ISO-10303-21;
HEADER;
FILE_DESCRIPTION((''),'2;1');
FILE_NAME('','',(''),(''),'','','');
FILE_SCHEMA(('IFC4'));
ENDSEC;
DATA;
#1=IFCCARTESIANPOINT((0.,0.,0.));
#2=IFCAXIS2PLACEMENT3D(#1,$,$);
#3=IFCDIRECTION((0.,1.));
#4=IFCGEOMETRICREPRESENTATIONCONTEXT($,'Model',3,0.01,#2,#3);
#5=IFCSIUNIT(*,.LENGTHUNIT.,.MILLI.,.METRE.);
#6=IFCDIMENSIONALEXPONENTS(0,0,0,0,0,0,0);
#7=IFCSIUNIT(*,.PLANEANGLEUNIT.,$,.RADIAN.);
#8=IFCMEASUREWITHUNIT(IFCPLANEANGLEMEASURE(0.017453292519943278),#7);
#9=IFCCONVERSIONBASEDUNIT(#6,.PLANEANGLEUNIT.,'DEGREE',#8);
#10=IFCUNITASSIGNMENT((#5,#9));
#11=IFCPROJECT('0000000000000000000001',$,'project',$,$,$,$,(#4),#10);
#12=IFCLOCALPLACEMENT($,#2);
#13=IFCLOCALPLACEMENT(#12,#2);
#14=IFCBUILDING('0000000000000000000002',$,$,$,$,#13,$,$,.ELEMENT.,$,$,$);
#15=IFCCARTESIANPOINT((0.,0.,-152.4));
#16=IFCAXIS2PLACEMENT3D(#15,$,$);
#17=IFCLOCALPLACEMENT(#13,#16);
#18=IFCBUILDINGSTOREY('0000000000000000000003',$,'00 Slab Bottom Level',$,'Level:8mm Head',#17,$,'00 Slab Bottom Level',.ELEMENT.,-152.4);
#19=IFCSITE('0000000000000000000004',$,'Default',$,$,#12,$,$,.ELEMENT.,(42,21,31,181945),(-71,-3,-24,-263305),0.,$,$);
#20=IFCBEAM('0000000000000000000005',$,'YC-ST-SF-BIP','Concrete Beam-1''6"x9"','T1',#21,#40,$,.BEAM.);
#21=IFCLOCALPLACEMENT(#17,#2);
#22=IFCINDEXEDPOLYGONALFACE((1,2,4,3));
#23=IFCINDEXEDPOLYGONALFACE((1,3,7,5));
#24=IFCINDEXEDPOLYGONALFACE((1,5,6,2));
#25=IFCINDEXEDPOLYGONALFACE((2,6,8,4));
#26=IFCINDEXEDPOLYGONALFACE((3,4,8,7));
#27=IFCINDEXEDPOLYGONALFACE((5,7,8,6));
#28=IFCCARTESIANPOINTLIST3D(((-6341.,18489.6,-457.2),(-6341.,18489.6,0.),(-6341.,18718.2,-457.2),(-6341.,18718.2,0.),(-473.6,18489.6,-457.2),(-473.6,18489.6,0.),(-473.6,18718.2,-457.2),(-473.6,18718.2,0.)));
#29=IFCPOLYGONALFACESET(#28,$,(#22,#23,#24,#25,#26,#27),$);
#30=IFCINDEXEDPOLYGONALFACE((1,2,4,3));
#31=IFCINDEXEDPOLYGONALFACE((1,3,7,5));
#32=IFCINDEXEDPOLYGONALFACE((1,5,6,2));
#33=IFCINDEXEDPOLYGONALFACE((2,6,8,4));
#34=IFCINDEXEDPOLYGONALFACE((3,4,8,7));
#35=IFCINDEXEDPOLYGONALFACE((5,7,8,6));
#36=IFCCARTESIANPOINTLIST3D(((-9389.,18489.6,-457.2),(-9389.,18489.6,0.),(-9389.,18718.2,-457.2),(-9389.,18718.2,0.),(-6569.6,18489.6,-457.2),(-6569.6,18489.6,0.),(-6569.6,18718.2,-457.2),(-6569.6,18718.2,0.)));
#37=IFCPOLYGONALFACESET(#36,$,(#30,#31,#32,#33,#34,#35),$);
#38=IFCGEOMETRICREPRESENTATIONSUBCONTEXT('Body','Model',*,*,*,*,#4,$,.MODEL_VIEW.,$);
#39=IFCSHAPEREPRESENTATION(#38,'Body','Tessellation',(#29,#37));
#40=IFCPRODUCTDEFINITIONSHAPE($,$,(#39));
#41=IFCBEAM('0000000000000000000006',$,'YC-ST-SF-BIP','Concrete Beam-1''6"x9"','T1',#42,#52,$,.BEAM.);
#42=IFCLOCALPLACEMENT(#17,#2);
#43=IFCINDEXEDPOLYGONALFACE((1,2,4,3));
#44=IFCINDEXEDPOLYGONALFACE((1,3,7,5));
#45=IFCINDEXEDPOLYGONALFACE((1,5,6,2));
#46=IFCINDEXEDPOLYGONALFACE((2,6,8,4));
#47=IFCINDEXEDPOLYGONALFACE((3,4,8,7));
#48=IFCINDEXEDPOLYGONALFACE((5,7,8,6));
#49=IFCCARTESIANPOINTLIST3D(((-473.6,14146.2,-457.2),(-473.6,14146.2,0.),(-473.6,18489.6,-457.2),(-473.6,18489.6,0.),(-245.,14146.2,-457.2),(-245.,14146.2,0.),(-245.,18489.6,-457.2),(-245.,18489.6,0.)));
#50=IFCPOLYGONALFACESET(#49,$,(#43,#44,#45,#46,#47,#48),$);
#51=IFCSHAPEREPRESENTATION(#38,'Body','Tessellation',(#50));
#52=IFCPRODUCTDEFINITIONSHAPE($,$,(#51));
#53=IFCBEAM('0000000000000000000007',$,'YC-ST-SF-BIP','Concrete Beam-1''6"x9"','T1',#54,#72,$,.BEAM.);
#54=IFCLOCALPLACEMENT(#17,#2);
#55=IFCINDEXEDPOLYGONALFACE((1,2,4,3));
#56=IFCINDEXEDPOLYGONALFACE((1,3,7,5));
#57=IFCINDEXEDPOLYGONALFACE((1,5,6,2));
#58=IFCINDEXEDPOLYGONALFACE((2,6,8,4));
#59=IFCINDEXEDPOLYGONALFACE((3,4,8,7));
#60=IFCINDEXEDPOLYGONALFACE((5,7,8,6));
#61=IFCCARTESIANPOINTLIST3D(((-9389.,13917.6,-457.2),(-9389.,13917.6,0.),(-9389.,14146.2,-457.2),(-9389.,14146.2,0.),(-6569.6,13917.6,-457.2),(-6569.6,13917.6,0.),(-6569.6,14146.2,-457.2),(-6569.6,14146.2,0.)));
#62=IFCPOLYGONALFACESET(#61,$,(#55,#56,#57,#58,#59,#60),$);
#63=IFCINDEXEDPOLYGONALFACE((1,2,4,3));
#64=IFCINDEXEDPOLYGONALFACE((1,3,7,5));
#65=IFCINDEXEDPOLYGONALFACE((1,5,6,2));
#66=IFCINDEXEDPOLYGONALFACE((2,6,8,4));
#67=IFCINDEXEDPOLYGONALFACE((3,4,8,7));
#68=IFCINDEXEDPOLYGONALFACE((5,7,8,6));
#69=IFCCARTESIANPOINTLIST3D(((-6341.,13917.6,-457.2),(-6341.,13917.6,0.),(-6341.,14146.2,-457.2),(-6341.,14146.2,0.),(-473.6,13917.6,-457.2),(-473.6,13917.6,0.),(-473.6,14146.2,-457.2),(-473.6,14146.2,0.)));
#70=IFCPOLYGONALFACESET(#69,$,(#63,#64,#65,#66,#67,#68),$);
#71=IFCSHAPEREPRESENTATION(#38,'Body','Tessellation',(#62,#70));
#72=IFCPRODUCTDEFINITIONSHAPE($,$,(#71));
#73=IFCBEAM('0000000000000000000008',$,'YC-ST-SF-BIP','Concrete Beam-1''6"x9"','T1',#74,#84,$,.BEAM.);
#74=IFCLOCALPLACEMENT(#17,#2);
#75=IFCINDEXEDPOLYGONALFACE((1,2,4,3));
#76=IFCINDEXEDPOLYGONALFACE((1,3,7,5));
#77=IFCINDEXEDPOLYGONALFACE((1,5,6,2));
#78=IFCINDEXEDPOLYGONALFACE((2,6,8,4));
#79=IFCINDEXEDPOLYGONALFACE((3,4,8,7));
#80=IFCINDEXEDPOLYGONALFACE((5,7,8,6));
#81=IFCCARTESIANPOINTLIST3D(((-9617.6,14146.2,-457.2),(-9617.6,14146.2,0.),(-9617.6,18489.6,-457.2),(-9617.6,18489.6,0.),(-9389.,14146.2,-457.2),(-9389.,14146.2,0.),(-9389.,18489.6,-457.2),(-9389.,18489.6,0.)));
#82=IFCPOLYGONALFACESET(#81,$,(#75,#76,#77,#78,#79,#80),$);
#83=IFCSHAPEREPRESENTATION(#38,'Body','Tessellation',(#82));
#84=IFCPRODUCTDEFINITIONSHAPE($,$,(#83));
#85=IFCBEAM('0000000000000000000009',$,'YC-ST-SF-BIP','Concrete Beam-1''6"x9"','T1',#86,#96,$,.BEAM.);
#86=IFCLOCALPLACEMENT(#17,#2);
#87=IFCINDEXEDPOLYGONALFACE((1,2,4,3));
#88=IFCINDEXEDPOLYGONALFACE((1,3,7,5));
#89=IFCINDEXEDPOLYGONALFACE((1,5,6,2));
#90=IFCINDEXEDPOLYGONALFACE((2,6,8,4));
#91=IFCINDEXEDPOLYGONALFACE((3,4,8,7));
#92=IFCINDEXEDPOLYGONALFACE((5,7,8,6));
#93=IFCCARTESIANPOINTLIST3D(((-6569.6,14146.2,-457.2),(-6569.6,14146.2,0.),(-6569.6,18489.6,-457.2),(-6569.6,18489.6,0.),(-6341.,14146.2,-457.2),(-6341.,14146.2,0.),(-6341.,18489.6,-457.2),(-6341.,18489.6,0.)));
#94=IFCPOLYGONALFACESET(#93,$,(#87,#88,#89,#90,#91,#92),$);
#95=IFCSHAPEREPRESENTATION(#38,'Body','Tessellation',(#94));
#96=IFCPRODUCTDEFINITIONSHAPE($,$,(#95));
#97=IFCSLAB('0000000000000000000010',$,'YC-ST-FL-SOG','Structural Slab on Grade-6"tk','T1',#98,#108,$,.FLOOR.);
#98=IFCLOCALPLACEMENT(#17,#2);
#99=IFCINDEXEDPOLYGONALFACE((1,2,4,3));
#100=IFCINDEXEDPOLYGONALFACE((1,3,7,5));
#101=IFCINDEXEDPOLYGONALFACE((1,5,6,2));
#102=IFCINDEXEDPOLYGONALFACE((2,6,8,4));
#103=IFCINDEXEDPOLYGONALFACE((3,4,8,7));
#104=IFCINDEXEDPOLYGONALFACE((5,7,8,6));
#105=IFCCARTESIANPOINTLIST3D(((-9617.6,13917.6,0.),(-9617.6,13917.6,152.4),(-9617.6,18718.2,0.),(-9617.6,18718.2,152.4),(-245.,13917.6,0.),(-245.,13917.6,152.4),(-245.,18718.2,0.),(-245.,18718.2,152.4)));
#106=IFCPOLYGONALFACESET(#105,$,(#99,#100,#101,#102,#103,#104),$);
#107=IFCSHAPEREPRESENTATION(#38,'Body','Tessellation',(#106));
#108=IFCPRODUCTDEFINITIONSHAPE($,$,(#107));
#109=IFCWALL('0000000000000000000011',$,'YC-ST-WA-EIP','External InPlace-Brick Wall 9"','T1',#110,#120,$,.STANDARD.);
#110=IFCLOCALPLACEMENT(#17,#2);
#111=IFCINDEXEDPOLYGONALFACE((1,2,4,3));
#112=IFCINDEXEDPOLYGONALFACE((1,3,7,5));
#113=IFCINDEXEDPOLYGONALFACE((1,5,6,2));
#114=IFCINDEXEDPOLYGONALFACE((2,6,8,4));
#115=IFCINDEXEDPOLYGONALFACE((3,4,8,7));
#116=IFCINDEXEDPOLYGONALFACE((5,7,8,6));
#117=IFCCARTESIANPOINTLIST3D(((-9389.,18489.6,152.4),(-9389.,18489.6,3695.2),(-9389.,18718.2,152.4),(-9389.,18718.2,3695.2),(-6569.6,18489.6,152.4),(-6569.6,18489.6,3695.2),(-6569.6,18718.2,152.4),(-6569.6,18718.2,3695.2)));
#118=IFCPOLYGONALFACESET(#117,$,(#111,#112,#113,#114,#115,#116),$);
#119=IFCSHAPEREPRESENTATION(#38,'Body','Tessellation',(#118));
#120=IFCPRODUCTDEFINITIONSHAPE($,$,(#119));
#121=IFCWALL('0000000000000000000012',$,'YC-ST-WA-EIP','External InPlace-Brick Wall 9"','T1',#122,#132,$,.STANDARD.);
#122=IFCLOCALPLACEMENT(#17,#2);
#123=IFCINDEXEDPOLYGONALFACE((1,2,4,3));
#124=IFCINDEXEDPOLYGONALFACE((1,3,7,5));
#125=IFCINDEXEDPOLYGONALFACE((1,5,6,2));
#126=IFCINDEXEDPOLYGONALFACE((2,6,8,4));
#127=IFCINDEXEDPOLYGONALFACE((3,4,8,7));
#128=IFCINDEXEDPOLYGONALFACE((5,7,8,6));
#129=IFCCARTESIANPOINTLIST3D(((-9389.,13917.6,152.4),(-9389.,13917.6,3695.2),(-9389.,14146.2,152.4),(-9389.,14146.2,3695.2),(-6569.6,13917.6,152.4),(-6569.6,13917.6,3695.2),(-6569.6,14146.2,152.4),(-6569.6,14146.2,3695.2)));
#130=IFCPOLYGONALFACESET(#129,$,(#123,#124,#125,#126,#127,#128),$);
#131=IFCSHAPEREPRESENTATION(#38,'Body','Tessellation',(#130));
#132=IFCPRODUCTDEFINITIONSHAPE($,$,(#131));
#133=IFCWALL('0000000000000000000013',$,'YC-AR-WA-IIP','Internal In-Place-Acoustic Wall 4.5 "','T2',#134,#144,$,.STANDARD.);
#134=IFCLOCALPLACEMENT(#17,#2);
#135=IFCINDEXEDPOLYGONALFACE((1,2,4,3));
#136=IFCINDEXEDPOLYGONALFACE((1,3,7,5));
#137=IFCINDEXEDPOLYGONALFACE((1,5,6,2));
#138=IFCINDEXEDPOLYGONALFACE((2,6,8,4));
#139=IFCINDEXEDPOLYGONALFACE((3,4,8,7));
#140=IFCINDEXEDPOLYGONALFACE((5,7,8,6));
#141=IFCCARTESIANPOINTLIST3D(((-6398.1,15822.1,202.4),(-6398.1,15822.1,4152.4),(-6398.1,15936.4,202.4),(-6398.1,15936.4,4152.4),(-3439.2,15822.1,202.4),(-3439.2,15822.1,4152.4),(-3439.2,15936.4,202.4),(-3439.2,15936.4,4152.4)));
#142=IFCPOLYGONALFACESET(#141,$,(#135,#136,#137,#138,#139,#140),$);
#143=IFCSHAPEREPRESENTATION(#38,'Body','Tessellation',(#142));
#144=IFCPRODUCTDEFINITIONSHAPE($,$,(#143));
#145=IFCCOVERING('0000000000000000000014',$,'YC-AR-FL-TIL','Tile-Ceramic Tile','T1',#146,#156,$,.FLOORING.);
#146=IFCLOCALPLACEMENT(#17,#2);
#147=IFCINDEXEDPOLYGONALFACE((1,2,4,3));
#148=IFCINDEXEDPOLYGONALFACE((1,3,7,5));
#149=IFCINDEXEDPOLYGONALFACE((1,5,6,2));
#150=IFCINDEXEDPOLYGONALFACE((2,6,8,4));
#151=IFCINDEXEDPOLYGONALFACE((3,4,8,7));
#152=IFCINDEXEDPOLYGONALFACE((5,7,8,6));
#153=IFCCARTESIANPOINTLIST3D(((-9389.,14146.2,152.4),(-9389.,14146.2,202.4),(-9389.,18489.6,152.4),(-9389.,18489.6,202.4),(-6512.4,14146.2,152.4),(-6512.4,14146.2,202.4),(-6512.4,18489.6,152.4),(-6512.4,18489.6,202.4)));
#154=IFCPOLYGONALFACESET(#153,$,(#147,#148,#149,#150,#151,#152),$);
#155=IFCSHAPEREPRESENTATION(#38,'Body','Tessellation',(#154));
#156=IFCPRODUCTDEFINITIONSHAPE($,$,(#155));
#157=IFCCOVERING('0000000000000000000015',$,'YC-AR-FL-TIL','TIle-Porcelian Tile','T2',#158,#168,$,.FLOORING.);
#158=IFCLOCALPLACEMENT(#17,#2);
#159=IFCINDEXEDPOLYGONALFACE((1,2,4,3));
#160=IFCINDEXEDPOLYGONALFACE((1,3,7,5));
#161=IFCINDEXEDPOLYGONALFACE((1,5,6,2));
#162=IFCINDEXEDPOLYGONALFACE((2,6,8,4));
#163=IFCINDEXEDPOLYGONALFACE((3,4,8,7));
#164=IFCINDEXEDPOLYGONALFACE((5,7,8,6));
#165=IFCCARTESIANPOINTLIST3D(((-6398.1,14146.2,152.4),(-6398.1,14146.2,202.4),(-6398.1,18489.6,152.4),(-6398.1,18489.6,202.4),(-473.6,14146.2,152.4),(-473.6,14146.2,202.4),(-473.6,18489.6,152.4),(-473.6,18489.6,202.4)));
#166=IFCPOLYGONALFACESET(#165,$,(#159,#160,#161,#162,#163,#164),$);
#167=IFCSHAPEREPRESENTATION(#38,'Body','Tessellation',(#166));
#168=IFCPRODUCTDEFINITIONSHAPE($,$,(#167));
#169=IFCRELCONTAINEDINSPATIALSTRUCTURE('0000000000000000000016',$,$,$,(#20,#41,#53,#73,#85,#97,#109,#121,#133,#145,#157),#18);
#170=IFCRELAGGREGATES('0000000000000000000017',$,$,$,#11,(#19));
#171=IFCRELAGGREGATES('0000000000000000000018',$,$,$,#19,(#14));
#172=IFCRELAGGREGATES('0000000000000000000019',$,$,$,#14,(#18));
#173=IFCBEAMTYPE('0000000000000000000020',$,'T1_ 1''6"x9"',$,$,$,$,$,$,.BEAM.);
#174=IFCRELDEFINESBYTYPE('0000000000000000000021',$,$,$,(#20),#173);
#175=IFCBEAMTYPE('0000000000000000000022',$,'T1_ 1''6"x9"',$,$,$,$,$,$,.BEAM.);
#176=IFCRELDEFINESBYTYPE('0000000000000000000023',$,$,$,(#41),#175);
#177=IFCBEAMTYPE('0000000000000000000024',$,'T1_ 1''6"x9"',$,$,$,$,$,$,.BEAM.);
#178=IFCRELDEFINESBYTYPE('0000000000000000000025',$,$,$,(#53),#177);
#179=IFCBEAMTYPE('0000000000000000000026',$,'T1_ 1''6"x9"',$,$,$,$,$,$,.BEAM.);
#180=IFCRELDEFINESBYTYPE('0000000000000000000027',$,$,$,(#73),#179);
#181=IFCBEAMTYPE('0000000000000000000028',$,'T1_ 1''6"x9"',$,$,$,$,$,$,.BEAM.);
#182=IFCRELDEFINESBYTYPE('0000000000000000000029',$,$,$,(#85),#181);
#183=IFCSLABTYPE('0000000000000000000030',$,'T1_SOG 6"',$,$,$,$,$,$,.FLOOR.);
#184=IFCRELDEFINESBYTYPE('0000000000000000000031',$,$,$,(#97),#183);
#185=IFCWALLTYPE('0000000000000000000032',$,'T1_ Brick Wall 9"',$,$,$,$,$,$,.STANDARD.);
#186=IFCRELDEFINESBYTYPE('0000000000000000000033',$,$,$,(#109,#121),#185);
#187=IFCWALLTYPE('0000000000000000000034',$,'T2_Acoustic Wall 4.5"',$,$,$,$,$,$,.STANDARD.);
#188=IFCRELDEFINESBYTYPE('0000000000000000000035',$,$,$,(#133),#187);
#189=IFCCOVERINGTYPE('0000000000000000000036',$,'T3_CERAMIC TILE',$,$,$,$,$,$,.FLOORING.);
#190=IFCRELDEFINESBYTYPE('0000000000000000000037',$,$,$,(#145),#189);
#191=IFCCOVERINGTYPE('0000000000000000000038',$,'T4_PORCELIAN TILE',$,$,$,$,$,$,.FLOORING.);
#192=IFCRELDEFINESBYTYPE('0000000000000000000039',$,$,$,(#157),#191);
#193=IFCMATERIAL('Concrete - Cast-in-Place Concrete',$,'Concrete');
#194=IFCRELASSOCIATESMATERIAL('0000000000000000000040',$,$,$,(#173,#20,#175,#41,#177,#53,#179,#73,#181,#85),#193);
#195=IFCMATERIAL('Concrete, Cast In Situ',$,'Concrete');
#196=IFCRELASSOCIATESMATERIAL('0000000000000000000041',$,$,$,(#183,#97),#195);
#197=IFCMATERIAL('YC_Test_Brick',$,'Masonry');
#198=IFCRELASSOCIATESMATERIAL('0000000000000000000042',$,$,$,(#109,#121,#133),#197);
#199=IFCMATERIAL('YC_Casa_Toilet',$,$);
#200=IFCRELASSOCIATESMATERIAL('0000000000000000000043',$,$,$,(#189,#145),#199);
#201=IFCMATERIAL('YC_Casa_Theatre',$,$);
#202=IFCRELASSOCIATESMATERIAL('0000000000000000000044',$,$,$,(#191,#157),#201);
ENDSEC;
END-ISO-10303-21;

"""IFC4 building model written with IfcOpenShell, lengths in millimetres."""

from ifc_helpers import new_model, entity, si_unit, converted_unit, direction, frame, origin, place, context, subcontext, project, spatial, indexed_curve, outline, extrude, source, transform, mapped, material, type_object, type_shapes, element, save


model = new_model("IFC4")

# Units and contexts
model_context = context("Model", 3, precision=0.01, world=origin(), true_north=direction((0.0, 1.0)))
body_context = subcontext(model_context, "Body", "Model", "MODEL_VIEW")
ifc_project = project(units=[si_unit("LENGTHUNIT", "METRE", prefix="MILLI"), converted_unit("PLANEANGLEUNIT", "DEGREE", entity("IfcPlaneAngleMeasure", 0.017453292519943278), si_unit("PLANEANGLEUNIT", "RADIAN"), dimensions=[0, 0, 0, 0, 0, 0, 0])], contexts=[model_context])

# Site, building, storey
site_placement = place(None, origin())
site = spatial("IfcSite", under=ifc_project, at=site_placement, Name="Default", CompositionType="ELEMENT", RefLatitude=(42, 21, 31, 181945), RefLongitude=(-71, -3, -24, -263305), RefElevation=0.0)
building_placement = place(site_placement, origin())
building = spatial("IfcBuilding", under=site, at=building_placement, CompositionType="ELEMENT")
storey_placement = place(building_placement, frame((0.0, 0.0, -152.4)))
storey = spatial("IfcBuildingStorey", under=building, at=storey_placement, Name="00 Slab Bottom Level", ObjectType="Level:8mm Head", LongName="00 Slab Bottom Level", CompositionType="ELEMENT", Elevation=-152.4)

# Beams
ifc_material_1 = material(Name="Concrete - Cast-in-Place Concrete", Category="Concrete")
beam_type_1 = type_object("IfcBeamType", Name="T1_ 1'6\"x9\"", PredefinedType="BEAM", material=ifc_material_1)
shared_shape_1 = source(origin(), body_context, "Body", "SweptSolid", [
    extrude(outline(indexed_curve([(-228.6, -114.3), (228.6, -114.3), (228.6, 114.3), (-228.6, 114.3), (-228.6, -114.3)], self_intersect=False)), frame((-6341.0, 18603.9, -381.0), z_axis=(1.0, 0.0, 0.0), x_axis=(0.0, 0.0, -1.0)), (0.0, 0.0, 1.0), 5867.4),
    extrude(outline(indexed_curve([(-228.6, -114.3), (228.6, -114.3), (228.6, 114.3), (-228.6, 114.3), (-228.6, -114.3)], self_intersect=False)), frame((-9389.0, 18603.9, -381.0), z_axis=(1.0, 0.0, 0.0), x_axis=(0.0, 0.0, -1.0)), (0.0, 0.0, 1.0), 2819.4),
])
type_shapes(beam_type_1, [shared_shape_1])
beam_1_placement = place(storey_placement, frame((0.0, 0.0, 152.4)))
element("IfcBeam", 1, at=beam_1_placement, inside=storey, type_object=beam_type_1, material=ifc_material_1, Name="YC-ST-SF-BIP", Description="Concrete Beam-1'6\"x9\"", ObjectType="T1", PredefinedType="BEAM", context=body_context, shape_type="MappedRepresentation", body=[
    mapped(shared_shape_1, transform((0.0, 0.0, 0.0), scale=1.0)),
])
beam_type_2 = type_object("IfcBeamType", Name="T1_ 1'6\"x9\"", PredefinedType="BEAM", material=ifc_material_1)
shared_shape_2 = source(origin(), body_context, "Body", "SweptSolid", [
    extrude(outline(indexed_curve([(-114.3, -228.6), (114.3, -228.6), (114.3, 228.6), (-114.3, 228.6), (-114.3, -228.6)], self_intersect=False)), frame((-359.3, 18489.6, -381.0), z_axis=(0.0, -1.0, 0.0), x_axis=(-1.0, 0.0, 0.0)), (0.0, 0.0, 1.0), 4343.4),
])
type_shapes(beam_type_2, [shared_shape_2])
beam_2_placement = place(storey_placement, frame((0.0, 0.0, 152.4)))
element("IfcBeam", 2, at=beam_2_placement, inside=storey, type_object=beam_type_2, material=ifc_material_1, Name="YC-ST-SF-BIP", Description="Concrete Beam-1'6\"x9\"", ObjectType="T1", PredefinedType="BEAM", context=body_context, shape_type="MappedRepresentation", body=[
    mapped(shared_shape_2, transform((0.0, 0.0, 0.0), scale=1.0)),
])
beam_type_3 = type_object("IfcBeamType", Name="T1_ 1'6\"x9\"", PredefinedType="BEAM", material=ifc_material_1)
shared_shape_3 = source(origin(), body_context, "Body", "SweptSolid", [
    extrude(outline(indexed_curve([(-228.6, -114.3), (228.6, -114.3), (228.6, 114.3), (-228.6, 114.3), (-228.6, -114.3)], self_intersect=False)), frame((-6569.6, 14031.9, -381.0), z_axis=(-1.0, 0.0, 0.0), x_axis=(0.0, 0.0, -1.0)), (0.0, 0.0, 1.0), 2819.4),
    extrude(outline(indexed_curve([(-228.6, -114.3), (228.6, -114.3), (228.6, 114.3), (-228.6, 114.3), (-228.6, -114.3)], self_intersect=False)), frame((-473.6, 14031.9, -381.0), z_axis=(-1.0, 0.0, 0.0), x_axis=(0.0, 0.0, -1.0)), (0.0, 0.0, 1.0), 5867.4),
])
type_shapes(beam_type_3, [shared_shape_3])
beam_3_placement = place(storey_placement, frame((0.0, 0.0, 152.4)))
element("IfcBeam", 3, at=beam_3_placement, inside=storey, type_object=beam_type_3, material=ifc_material_1, Name="YC-ST-SF-BIP", Description="Concrete Beam-1'6\"x9\"", ObjectType="T1", PredefinedType="BEAM", context=body_context, shape_type="MappedRepresentation", body=[
    mapped(shared_shape_3, transform((0.0, 0.0, 0.0), scale=1.0)),
])
beam_type_4 = type_object("IfcBeamType", Name="T1_ 1'6\"x9\"", PredefinedType="BEAM", material=ifc_material_1)
shared_shape_4 = source(origin(), body_context, "Body", "SweptSolid", [
    extrude(outline(indexed_curve([(-114.3, -228.6), (114.3, -228.6), (114.3, 228.6), (-114.3, 228.6), (-114.3, -228.6)], self_intersect=False)), frame((-9503.3, 14146.2, -381.0), z_axis=(0.0, 1.0, 0.0), x_axis=(-1.0, 0.0, 0.0)), (0.0, 0.0, 1.0), 4343.4),
])
type_shapes(beam_type_4, [shared_shape_4])
beam_4_placement = place(storey_placement, frame((0.0, 0.0, 152.4)))
element("IfcBeam", 4, at=beam_4_placement, inside=storey, type_object=beam_type_4, material=ifc_material_1, Name="YC-ST-SF-BIP", Description="Concrete Beam-1'6\"x9\"", ObjectType="T1", PredefinedType="BEAM", context=body_context, shape_type="MappedRepresentation", body=[
    mapped(shared_shape_4, transform((0.0, 0.0, 0.0), scale=1.0)),
])
beam_type_5 = type_object("IfcBeamType", Name="T1_ 1'6\"x9\"", PredefinedType="BEAM", material=ifc_material_1)
shared_shape_5 = source(origin(), body_context, "Body", "SweptSolid", [
    extrude(outline(indexed_curve([(-114.3, -228.6), (114.3, -228.6), (114.3, 228.6), (-114.3, 228.6), (-114.3, -228.6)], self_intersect=False)), frame((-6455.3, 18489.6, -381.0), z_axis=(0.0, -1.0, 0.0), x_axis=(-1.0, 0.0, 0.0)), (0.0, 0.0, 1.0), 4343.4),
])
type_shapes(beam_type_5, [shared_shape_5])
beam_5_placement = place(storey_placement, frame((0.0, 0.0, 152.4)))
element("IfcBeam", 5, at=beam_5_placement, inside=storey, type_object=beam_type_5, material=ifc_material_1, Name="YC-ST-SF-BIP", Description="Concrete Beam-1'6\"x9\"", ObjectType="T1", PredefinedType="BEAM", context=body_context, shape_type="MappedRepresentation", body=[
    mapped(shared_shape_5, transform((0.0, 0.0, 0.0), scale=1.0)),
])

# Slab
ifc_material_2 = material(Name="Concrete, Cast In Situ", Category="Concrete")
slab_type = type_object("IfcSlabType", Name="T1_SOG 6\"", PredefinedType="FLOOR", material=ifc_material_2)
slab_placement = place(storey_placement, origin())
element("IfcSlab", 6, at=slab_placement, inside=storey, type_object=slab_type, material=ifc_material_2, Name="YC-ST-FL-SOG", Description="Structural Slab on Grade-6\"tk", ObjectType="T1", PredefinedType="FLOOR", context=body_context, shape_type="SweptSolid", body=[
    extrude(outline(indexed_curve([(-2400.3, -4686.3), (2400.3, -4686.3), (2400.3, 4686.3), (-2400.3, 4686.3), (-2400.3, -4686.3)], self_intersect=False)), frame((-4931.3, 16317.9, 152.4), z_axis=(0.0, 0.0, -1.0), x_axis=(0.0, 1.0, 0.0)), (0.0, 0.0, 1.0), 152.4),
])

# Walls
ifc_material_3 = material(Name="YC_Test_Brick", Category="Masonry")
wall_type_1 = type_object("IfcWallType", Name="T1_ Brick Wall 9\"", PredefinedType="STANDARD")
wall_1_placement = place(storey_placement, frame((-6569.6, 18603.9, 152.4), z_axis=(0.0, 0.0, 1.0), x_axis=(-1.0, 0.0, 0.0)))
element("IfcWall", 7, at=wall_1_placement, inside=storey, type_object=wall_type_1, material=ifc_material_3, Name="YC-ST-WA-EIP", Description="External InPlace-Brick Wall 9\"", ObjectType="T1", PredefinedType="STANDARD", context=body_context, shape_type="SweptSolid", body=[
    extrude(outline(indexed_curve([(2819.4, 114.3), (0.0, 114.3), (0.0, -114.3), (2819.4, -114.3), (2819.4, 114.3)], self_intersect=False)), origin(), (0.0, 0.0, 1.0), 3542.8),
])
wall_2_placement = place(storey_placement, frame((-6569.6, 14031.9, 152.4), z_axis=(0.0, 0.0, 1.0), x_axis=(-1.0, 0.0, 0.0)))
element("IfcWall", 8, at=wall_2_placement, inside=storey, type_object=wall_type_1, material=ifc_material_3, Name="YC-ST-WA-EIP", Description="External InPlace-Brick Wall 9\"", ObjectType="T1", PredefinedType="STANDARD", context=body_context, shape_type="SweptSolid", body=[
    extrude(outline(indexed_curve([(2819.4, 114.3), (0.0, 114.3), (0.0, -114.3), (2819.4, -114.3), (2819.4, 114.3)], self_intersect=False)), origin(), (0.0, 0.0, 1.0), 3542.8),
])
wall_type_2 = type_object("IfcWallType", Name="T2_Acoustic Wall 4.5\"", PredefinedType="STANDARD")
wall_3_placement = place(storey_placement, frame((-6398.1, 15879.2, 202.4)))
element("IfcWall", 9, at=wall_3_placement, inside=storey, type_object=wall_type_2, material=ifc_material_3, Name="YC-AR-WA-IIP", Description="Internal In-Place-Acoustic Wall 4.5 \"", ObjectType="T2", PredefinedType="STANDARD", context=body_context, shape_type="SweptSolid", body=[
    extrude(outline(indexed_curve([(2958.9, 57.1), (0.0, 57.2), (0.0, -57.2), (2958.9, -57.2), (2958.9, 57.1)], self_intersect=False)), origin(), (0.0, 0.0, 1.0), 3950.0),
])

# Coverings
ifc_material_4 = material(Name="YC_Casa_Toilet")
covering_type_1 = type_object("IfcCoveringType", Name="T3_CERAMIC TILE", PredefinedType="FLOORING", material=ifc_material_4)
covering_1_placement = place(storey_placement, origin())
element("IfcCovering", 10, at=covering_1_placement, inside=storey, type_object=covering_type_1, material=ifc_material_4, Name="YC-AR-FL-TIL", Description="Tile-Ceramic Tile", ObjectType="T1", PredefinedType="FLOORING", context=body_context, shape_type="SweptSolid", body=[
    extrude(outline(indexed_curve([(-2171.7, -1438.3), (2171.7, -1438.3), (2171.7, 1438.3), (-2171.7, 1438.3), (-2171.7, -1438.3)], self_intersect=False)), frame((-7950.7, 16317.9, 202.4), z_axis=(0.0, 0.0, -1.0), x_axis=(0.0, 1.0, 0.0)), (0.0, 0.0, 1.0), 50.0),
])
ifc_material_5 = material(Name="YC_Casa_Theatre")
covering_type_2 = type_object("IfcCoveringType", Name="T4_PORCELIAN TILE", PredefinedType="FLOORING", material=ifc_material_5)
covering_2_placement = place(storey_placement, origin())
element("IfcCovering", 11, at=covering_2_placement, inside=storey, type_object=covering_type_2, material=ifc_material_5, Name="YC-AR-FL-TIL", Description="TIle-Porcelian Tile", ObjectType="T2", PredefinedType="FLOORING", context=body_context, shape_type="SweptSolid", body=[
    extrude(outline(indexed_curve([(-2171.7, -2962.3), (2171.7, -2962.3), (2171.7, 2962.3), (-2171.7, 2962.3), (-2171.7, -2962.3)], self_intersect=False)), frame((-3435.8, 16317.9, 202.4), z_axis=(0.0, 0.0, -1.0), x_axis=(0.0, 1.0, 0.0)), (0.0, 0.0, 1.0), 50.0),
])

save(model, "model.ifc")
